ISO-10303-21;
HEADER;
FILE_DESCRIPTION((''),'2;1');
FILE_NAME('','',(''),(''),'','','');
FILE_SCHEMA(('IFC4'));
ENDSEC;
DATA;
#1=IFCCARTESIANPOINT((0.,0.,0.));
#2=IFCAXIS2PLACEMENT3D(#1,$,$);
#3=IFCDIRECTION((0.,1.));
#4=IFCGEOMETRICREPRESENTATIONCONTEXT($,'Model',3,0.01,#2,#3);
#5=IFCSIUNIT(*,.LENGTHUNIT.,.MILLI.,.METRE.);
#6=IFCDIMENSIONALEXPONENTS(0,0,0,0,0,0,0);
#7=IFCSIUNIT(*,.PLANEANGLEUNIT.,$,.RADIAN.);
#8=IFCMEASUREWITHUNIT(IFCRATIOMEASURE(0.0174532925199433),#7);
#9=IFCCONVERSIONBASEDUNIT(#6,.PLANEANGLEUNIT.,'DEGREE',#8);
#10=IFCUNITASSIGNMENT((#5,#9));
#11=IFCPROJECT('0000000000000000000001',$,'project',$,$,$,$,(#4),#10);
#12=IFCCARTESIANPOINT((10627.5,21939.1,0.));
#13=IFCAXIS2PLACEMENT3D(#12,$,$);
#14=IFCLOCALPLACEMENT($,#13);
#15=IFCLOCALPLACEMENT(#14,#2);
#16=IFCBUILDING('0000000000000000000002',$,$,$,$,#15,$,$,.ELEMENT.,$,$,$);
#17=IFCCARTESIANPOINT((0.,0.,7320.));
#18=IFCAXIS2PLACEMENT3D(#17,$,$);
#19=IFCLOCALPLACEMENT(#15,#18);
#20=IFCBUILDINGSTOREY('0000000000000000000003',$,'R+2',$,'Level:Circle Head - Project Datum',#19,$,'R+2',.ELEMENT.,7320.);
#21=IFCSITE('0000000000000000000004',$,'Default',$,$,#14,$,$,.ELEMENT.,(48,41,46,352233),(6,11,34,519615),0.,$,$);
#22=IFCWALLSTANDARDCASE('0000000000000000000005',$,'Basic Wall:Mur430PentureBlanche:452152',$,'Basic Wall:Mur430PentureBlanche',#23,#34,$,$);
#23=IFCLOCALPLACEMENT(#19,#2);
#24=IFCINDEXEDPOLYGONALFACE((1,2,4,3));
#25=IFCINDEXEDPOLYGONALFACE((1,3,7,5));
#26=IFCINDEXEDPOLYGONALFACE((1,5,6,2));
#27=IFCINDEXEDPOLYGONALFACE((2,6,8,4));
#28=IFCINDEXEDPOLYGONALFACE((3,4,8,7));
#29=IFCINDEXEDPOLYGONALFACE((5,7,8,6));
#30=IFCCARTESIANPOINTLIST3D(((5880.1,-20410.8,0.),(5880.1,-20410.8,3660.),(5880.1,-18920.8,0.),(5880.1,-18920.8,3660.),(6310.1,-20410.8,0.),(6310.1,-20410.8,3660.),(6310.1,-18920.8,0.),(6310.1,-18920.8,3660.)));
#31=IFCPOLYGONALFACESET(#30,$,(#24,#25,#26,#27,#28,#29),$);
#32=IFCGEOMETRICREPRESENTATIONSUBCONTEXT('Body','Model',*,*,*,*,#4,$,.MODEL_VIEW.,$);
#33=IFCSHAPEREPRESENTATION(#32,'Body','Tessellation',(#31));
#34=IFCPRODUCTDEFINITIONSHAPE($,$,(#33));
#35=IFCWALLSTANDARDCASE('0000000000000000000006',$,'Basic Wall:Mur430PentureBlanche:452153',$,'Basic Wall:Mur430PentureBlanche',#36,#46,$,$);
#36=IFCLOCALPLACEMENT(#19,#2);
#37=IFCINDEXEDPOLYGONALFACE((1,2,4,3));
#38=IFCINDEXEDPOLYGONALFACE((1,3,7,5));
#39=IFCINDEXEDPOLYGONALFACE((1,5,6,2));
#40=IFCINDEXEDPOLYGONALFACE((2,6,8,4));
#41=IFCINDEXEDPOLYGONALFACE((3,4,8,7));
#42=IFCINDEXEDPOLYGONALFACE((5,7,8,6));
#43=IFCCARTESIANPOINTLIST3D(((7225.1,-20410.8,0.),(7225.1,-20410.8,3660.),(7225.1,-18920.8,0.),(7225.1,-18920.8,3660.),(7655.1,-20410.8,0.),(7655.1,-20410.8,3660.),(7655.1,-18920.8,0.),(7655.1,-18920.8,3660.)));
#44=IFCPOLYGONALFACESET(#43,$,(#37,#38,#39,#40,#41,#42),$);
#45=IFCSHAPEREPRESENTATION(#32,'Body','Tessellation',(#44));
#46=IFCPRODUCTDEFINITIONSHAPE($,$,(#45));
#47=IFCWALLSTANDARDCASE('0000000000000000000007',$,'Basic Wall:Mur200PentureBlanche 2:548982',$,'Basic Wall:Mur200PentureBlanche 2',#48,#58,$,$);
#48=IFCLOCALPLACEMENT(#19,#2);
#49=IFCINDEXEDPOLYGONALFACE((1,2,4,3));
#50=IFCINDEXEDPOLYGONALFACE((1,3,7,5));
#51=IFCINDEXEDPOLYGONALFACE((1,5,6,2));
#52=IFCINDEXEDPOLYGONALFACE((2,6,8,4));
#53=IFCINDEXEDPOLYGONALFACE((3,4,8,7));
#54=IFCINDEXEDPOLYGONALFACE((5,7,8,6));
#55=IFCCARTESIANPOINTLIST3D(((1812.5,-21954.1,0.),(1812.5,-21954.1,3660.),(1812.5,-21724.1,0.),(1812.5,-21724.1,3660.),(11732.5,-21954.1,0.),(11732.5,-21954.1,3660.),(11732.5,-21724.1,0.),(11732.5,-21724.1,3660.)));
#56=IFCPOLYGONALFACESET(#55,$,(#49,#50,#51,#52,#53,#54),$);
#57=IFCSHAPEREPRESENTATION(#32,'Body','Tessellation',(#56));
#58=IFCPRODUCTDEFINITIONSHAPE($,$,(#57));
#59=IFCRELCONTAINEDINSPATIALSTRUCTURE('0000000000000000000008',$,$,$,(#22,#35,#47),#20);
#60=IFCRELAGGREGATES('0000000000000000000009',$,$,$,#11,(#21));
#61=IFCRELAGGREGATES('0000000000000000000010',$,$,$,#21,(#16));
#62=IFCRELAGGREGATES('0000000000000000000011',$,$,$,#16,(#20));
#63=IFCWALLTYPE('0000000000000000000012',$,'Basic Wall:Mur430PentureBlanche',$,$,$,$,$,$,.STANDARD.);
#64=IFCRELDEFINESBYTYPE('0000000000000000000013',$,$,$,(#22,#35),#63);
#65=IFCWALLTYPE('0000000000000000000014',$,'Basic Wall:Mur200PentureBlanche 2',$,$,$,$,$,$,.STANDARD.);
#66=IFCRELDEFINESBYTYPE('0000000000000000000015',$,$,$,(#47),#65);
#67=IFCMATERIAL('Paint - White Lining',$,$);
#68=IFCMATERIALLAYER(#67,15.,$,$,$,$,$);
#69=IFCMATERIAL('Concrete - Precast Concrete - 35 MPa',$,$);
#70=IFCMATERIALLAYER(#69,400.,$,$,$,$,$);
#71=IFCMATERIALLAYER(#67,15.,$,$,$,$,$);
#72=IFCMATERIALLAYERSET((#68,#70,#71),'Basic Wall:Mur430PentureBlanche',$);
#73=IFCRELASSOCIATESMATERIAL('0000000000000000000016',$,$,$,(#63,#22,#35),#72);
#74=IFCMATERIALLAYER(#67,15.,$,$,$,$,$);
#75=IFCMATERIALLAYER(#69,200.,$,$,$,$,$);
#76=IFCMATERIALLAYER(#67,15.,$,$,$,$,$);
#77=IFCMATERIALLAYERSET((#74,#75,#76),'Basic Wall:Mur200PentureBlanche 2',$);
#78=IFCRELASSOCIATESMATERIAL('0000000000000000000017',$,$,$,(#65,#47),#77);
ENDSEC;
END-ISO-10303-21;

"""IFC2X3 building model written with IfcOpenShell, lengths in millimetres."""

from ifc_helpers import new_model, entity, si_unit, converted_unit, direction, frame, frame_2d, origin, place, context, subcontext, project, spatial, rectangle, extrude, material, layer, layer_set, layer_usage, type_object, element, save


model = new_model("IFC2X3")

# Units and contexts
model_context = context("Model", 3, precision=0.01, world=origin(), true_north=direction((0.0, 1.0)))
body_context = subcontext(model_context, "Body", "Model", "MODEL_VIEW")
ifc_project = project(units=[si_unit("LENGTHUNIT", "METRE", prefix="MILLI"), converted_unit("PLANEANGLEUNIT", "DEGREE", entity("IfcRatioMeasure", 0.0174532925199433), si_unit("PLANEANGLEUNIT", "RADIAN"), dimensions=[0, 0, 0, 0, 0, 0, 0])], contexts=[model_context])

# Site, building, storey
site_placement = place(None, frame((10627.5, 21939.1, 0.0)))
site = spatial("IfcSite", under=ifc_project, at=site_placement, Name="Default", CompositionType="ELEMENT", RefLatitude=(48, 41, 46, 352233), RefLongitude=(6, 11, 34, 519615), RefElevation=0.0)
building_placement = place(site_placement, origin())
building = spatial("IfcBuilding", under=site, at=building_placement, CompositionType="ELEMENT")
storey_placement = place(building_placement, frame((0.0, 0.0, 7320.0)))
storey = spatial("IfcBuildingStorey", under=building, at=storey_placement, Name="R+2", ObjectType="Level:Circle Head - Project Datum", LongName="R+2", CompositionType="ELEMENT", Elevation=7320.0)

# Walls
ifc_material_1 = material(Name="Paint - White Lining")
ifc_layer_1 = layer(ifc_material_1, 15.0)
ifc_material_2 = material(Name="Concrete - Precast Concrete - 35 MPa")
ifc_layer_2 = layer(ifc_material_2, 400.0)
ifc_layer_3 = layer(ifc_material_1, 15.0)
ifc_layer_set_1 = layer_set([ifc_layer_1, ifc_layer_2, ifc_layer_3], Name="Basic Wall:Mur430PentureBlanche")
ifc_layer_usage_1 = layer_usage(ifc_layer_set_1, "AXIS2", "NEGATIVE", 215.0)
wall_type_1 = type_object("IfcWallType", Name="Basic Wall:Mur430PentureBlanche", PredefinedType="STANDARD", material=ifc_layer_set_1)
wall_1_placement = place(storey_placement, frame((6095.1, -18920.8, 0.0), z_axis=(0.0, 0.0, 1.0), x_axis=(0.0, -1.0, 0.0)))
element("IfcWallStandardCase", 1, at=wall_1_placement, inside=storey, type_object=wall_type_1, material=ifc_layer_usage_1, Name="Basic Wall:Mur430PentureBlanche:452152", ObjectType="Basic Wall:Mur430PentureBlanche", context=body_context, shape_type="SweptSolid", body=[
    extrude(rectangle(XDim=1490.0, YDim=430.0, at=frame_2d((745.0, 0.0), x_axis=(-1.0, 0.0))), origin(), (0.0, 0.0, 1.0), 3660.0),
])
ifc_layer_usage_2 = layer_usage(ifc_layer_set_1, "AXIS2", "NEGATIVE", 215.0)
wall_2_placement = place(storey_placement, frame((7440.1, -18920.8, 0.0), z_axis=(0.0, 0.0, 1.0), x_axis=(0.0, -1.0, 0.0)))
element("IfcWallStandardCase", 2, at=wall_2_placement, inside=storey, type_object=wall_type_1, material=ifc_layer_usage_2, Name="Basic Wall:Mur430PentureBlanche:452153", ObjectType="Basic Wall:Mur430PentureBlanche", context=body_context, shape_type="SweptSolid", body=[
    extrude(rectangle(XDim=1490.0, YDim=430.0, at=frame_2d((745.0, 0.0), x_axis=(-1.0, 0.0))), origin(), (0.0, 0.0, 1.0), 3660.0),
])
ifc_layer_4 = layer(ifc_material_1, 15.0)
ifc_layer_5 = layer(ifc_material_2, 200.0)
ifc_layer_6 = layer(ifc_material_1, 15.0)
ifc_layer_set_2 = layer_set([ifc_layer_4, ifc_layer_5, ifc_layer_6], Name="Basic Wall:Mur200PentureBlanche 2")
ifc_layer_usage_3 = layer_usage(ifc_layer_set_2, "AXIS2", "NEGATIVE", 115.0)
wall_type_2 = type_object("IfcWallType", Name="Basic Wall:Mur200PentureBlanche 2", PredefinedType="STANDARD", material=ifc_layer_set_2)
wall_3_placement = place(storey_placement, frame((1812.5, -21839.1, 0.0)))
element("IfcWallStandardCase", 3, at=wall_3_placement, inside=storey, type_object=wall_type_2, material=ifc_layer_usage_3, Name="Basic Wall:Mur200PentureBlanche 2:548982", ObjectType="Basic Wall:Mur200PentureBlanche 2", context=body_context, shape_type="SweptSolid", body=[
    extrude(rectangle(XDim=9920.0, YDim=230.0, at=frame_2d((4960.0, 0.0), x_axis=(-1.0, 0.0))), origin(), (0.0, 0.0, 1.0), 3660.0),
])

save(model, "model.ifc")
